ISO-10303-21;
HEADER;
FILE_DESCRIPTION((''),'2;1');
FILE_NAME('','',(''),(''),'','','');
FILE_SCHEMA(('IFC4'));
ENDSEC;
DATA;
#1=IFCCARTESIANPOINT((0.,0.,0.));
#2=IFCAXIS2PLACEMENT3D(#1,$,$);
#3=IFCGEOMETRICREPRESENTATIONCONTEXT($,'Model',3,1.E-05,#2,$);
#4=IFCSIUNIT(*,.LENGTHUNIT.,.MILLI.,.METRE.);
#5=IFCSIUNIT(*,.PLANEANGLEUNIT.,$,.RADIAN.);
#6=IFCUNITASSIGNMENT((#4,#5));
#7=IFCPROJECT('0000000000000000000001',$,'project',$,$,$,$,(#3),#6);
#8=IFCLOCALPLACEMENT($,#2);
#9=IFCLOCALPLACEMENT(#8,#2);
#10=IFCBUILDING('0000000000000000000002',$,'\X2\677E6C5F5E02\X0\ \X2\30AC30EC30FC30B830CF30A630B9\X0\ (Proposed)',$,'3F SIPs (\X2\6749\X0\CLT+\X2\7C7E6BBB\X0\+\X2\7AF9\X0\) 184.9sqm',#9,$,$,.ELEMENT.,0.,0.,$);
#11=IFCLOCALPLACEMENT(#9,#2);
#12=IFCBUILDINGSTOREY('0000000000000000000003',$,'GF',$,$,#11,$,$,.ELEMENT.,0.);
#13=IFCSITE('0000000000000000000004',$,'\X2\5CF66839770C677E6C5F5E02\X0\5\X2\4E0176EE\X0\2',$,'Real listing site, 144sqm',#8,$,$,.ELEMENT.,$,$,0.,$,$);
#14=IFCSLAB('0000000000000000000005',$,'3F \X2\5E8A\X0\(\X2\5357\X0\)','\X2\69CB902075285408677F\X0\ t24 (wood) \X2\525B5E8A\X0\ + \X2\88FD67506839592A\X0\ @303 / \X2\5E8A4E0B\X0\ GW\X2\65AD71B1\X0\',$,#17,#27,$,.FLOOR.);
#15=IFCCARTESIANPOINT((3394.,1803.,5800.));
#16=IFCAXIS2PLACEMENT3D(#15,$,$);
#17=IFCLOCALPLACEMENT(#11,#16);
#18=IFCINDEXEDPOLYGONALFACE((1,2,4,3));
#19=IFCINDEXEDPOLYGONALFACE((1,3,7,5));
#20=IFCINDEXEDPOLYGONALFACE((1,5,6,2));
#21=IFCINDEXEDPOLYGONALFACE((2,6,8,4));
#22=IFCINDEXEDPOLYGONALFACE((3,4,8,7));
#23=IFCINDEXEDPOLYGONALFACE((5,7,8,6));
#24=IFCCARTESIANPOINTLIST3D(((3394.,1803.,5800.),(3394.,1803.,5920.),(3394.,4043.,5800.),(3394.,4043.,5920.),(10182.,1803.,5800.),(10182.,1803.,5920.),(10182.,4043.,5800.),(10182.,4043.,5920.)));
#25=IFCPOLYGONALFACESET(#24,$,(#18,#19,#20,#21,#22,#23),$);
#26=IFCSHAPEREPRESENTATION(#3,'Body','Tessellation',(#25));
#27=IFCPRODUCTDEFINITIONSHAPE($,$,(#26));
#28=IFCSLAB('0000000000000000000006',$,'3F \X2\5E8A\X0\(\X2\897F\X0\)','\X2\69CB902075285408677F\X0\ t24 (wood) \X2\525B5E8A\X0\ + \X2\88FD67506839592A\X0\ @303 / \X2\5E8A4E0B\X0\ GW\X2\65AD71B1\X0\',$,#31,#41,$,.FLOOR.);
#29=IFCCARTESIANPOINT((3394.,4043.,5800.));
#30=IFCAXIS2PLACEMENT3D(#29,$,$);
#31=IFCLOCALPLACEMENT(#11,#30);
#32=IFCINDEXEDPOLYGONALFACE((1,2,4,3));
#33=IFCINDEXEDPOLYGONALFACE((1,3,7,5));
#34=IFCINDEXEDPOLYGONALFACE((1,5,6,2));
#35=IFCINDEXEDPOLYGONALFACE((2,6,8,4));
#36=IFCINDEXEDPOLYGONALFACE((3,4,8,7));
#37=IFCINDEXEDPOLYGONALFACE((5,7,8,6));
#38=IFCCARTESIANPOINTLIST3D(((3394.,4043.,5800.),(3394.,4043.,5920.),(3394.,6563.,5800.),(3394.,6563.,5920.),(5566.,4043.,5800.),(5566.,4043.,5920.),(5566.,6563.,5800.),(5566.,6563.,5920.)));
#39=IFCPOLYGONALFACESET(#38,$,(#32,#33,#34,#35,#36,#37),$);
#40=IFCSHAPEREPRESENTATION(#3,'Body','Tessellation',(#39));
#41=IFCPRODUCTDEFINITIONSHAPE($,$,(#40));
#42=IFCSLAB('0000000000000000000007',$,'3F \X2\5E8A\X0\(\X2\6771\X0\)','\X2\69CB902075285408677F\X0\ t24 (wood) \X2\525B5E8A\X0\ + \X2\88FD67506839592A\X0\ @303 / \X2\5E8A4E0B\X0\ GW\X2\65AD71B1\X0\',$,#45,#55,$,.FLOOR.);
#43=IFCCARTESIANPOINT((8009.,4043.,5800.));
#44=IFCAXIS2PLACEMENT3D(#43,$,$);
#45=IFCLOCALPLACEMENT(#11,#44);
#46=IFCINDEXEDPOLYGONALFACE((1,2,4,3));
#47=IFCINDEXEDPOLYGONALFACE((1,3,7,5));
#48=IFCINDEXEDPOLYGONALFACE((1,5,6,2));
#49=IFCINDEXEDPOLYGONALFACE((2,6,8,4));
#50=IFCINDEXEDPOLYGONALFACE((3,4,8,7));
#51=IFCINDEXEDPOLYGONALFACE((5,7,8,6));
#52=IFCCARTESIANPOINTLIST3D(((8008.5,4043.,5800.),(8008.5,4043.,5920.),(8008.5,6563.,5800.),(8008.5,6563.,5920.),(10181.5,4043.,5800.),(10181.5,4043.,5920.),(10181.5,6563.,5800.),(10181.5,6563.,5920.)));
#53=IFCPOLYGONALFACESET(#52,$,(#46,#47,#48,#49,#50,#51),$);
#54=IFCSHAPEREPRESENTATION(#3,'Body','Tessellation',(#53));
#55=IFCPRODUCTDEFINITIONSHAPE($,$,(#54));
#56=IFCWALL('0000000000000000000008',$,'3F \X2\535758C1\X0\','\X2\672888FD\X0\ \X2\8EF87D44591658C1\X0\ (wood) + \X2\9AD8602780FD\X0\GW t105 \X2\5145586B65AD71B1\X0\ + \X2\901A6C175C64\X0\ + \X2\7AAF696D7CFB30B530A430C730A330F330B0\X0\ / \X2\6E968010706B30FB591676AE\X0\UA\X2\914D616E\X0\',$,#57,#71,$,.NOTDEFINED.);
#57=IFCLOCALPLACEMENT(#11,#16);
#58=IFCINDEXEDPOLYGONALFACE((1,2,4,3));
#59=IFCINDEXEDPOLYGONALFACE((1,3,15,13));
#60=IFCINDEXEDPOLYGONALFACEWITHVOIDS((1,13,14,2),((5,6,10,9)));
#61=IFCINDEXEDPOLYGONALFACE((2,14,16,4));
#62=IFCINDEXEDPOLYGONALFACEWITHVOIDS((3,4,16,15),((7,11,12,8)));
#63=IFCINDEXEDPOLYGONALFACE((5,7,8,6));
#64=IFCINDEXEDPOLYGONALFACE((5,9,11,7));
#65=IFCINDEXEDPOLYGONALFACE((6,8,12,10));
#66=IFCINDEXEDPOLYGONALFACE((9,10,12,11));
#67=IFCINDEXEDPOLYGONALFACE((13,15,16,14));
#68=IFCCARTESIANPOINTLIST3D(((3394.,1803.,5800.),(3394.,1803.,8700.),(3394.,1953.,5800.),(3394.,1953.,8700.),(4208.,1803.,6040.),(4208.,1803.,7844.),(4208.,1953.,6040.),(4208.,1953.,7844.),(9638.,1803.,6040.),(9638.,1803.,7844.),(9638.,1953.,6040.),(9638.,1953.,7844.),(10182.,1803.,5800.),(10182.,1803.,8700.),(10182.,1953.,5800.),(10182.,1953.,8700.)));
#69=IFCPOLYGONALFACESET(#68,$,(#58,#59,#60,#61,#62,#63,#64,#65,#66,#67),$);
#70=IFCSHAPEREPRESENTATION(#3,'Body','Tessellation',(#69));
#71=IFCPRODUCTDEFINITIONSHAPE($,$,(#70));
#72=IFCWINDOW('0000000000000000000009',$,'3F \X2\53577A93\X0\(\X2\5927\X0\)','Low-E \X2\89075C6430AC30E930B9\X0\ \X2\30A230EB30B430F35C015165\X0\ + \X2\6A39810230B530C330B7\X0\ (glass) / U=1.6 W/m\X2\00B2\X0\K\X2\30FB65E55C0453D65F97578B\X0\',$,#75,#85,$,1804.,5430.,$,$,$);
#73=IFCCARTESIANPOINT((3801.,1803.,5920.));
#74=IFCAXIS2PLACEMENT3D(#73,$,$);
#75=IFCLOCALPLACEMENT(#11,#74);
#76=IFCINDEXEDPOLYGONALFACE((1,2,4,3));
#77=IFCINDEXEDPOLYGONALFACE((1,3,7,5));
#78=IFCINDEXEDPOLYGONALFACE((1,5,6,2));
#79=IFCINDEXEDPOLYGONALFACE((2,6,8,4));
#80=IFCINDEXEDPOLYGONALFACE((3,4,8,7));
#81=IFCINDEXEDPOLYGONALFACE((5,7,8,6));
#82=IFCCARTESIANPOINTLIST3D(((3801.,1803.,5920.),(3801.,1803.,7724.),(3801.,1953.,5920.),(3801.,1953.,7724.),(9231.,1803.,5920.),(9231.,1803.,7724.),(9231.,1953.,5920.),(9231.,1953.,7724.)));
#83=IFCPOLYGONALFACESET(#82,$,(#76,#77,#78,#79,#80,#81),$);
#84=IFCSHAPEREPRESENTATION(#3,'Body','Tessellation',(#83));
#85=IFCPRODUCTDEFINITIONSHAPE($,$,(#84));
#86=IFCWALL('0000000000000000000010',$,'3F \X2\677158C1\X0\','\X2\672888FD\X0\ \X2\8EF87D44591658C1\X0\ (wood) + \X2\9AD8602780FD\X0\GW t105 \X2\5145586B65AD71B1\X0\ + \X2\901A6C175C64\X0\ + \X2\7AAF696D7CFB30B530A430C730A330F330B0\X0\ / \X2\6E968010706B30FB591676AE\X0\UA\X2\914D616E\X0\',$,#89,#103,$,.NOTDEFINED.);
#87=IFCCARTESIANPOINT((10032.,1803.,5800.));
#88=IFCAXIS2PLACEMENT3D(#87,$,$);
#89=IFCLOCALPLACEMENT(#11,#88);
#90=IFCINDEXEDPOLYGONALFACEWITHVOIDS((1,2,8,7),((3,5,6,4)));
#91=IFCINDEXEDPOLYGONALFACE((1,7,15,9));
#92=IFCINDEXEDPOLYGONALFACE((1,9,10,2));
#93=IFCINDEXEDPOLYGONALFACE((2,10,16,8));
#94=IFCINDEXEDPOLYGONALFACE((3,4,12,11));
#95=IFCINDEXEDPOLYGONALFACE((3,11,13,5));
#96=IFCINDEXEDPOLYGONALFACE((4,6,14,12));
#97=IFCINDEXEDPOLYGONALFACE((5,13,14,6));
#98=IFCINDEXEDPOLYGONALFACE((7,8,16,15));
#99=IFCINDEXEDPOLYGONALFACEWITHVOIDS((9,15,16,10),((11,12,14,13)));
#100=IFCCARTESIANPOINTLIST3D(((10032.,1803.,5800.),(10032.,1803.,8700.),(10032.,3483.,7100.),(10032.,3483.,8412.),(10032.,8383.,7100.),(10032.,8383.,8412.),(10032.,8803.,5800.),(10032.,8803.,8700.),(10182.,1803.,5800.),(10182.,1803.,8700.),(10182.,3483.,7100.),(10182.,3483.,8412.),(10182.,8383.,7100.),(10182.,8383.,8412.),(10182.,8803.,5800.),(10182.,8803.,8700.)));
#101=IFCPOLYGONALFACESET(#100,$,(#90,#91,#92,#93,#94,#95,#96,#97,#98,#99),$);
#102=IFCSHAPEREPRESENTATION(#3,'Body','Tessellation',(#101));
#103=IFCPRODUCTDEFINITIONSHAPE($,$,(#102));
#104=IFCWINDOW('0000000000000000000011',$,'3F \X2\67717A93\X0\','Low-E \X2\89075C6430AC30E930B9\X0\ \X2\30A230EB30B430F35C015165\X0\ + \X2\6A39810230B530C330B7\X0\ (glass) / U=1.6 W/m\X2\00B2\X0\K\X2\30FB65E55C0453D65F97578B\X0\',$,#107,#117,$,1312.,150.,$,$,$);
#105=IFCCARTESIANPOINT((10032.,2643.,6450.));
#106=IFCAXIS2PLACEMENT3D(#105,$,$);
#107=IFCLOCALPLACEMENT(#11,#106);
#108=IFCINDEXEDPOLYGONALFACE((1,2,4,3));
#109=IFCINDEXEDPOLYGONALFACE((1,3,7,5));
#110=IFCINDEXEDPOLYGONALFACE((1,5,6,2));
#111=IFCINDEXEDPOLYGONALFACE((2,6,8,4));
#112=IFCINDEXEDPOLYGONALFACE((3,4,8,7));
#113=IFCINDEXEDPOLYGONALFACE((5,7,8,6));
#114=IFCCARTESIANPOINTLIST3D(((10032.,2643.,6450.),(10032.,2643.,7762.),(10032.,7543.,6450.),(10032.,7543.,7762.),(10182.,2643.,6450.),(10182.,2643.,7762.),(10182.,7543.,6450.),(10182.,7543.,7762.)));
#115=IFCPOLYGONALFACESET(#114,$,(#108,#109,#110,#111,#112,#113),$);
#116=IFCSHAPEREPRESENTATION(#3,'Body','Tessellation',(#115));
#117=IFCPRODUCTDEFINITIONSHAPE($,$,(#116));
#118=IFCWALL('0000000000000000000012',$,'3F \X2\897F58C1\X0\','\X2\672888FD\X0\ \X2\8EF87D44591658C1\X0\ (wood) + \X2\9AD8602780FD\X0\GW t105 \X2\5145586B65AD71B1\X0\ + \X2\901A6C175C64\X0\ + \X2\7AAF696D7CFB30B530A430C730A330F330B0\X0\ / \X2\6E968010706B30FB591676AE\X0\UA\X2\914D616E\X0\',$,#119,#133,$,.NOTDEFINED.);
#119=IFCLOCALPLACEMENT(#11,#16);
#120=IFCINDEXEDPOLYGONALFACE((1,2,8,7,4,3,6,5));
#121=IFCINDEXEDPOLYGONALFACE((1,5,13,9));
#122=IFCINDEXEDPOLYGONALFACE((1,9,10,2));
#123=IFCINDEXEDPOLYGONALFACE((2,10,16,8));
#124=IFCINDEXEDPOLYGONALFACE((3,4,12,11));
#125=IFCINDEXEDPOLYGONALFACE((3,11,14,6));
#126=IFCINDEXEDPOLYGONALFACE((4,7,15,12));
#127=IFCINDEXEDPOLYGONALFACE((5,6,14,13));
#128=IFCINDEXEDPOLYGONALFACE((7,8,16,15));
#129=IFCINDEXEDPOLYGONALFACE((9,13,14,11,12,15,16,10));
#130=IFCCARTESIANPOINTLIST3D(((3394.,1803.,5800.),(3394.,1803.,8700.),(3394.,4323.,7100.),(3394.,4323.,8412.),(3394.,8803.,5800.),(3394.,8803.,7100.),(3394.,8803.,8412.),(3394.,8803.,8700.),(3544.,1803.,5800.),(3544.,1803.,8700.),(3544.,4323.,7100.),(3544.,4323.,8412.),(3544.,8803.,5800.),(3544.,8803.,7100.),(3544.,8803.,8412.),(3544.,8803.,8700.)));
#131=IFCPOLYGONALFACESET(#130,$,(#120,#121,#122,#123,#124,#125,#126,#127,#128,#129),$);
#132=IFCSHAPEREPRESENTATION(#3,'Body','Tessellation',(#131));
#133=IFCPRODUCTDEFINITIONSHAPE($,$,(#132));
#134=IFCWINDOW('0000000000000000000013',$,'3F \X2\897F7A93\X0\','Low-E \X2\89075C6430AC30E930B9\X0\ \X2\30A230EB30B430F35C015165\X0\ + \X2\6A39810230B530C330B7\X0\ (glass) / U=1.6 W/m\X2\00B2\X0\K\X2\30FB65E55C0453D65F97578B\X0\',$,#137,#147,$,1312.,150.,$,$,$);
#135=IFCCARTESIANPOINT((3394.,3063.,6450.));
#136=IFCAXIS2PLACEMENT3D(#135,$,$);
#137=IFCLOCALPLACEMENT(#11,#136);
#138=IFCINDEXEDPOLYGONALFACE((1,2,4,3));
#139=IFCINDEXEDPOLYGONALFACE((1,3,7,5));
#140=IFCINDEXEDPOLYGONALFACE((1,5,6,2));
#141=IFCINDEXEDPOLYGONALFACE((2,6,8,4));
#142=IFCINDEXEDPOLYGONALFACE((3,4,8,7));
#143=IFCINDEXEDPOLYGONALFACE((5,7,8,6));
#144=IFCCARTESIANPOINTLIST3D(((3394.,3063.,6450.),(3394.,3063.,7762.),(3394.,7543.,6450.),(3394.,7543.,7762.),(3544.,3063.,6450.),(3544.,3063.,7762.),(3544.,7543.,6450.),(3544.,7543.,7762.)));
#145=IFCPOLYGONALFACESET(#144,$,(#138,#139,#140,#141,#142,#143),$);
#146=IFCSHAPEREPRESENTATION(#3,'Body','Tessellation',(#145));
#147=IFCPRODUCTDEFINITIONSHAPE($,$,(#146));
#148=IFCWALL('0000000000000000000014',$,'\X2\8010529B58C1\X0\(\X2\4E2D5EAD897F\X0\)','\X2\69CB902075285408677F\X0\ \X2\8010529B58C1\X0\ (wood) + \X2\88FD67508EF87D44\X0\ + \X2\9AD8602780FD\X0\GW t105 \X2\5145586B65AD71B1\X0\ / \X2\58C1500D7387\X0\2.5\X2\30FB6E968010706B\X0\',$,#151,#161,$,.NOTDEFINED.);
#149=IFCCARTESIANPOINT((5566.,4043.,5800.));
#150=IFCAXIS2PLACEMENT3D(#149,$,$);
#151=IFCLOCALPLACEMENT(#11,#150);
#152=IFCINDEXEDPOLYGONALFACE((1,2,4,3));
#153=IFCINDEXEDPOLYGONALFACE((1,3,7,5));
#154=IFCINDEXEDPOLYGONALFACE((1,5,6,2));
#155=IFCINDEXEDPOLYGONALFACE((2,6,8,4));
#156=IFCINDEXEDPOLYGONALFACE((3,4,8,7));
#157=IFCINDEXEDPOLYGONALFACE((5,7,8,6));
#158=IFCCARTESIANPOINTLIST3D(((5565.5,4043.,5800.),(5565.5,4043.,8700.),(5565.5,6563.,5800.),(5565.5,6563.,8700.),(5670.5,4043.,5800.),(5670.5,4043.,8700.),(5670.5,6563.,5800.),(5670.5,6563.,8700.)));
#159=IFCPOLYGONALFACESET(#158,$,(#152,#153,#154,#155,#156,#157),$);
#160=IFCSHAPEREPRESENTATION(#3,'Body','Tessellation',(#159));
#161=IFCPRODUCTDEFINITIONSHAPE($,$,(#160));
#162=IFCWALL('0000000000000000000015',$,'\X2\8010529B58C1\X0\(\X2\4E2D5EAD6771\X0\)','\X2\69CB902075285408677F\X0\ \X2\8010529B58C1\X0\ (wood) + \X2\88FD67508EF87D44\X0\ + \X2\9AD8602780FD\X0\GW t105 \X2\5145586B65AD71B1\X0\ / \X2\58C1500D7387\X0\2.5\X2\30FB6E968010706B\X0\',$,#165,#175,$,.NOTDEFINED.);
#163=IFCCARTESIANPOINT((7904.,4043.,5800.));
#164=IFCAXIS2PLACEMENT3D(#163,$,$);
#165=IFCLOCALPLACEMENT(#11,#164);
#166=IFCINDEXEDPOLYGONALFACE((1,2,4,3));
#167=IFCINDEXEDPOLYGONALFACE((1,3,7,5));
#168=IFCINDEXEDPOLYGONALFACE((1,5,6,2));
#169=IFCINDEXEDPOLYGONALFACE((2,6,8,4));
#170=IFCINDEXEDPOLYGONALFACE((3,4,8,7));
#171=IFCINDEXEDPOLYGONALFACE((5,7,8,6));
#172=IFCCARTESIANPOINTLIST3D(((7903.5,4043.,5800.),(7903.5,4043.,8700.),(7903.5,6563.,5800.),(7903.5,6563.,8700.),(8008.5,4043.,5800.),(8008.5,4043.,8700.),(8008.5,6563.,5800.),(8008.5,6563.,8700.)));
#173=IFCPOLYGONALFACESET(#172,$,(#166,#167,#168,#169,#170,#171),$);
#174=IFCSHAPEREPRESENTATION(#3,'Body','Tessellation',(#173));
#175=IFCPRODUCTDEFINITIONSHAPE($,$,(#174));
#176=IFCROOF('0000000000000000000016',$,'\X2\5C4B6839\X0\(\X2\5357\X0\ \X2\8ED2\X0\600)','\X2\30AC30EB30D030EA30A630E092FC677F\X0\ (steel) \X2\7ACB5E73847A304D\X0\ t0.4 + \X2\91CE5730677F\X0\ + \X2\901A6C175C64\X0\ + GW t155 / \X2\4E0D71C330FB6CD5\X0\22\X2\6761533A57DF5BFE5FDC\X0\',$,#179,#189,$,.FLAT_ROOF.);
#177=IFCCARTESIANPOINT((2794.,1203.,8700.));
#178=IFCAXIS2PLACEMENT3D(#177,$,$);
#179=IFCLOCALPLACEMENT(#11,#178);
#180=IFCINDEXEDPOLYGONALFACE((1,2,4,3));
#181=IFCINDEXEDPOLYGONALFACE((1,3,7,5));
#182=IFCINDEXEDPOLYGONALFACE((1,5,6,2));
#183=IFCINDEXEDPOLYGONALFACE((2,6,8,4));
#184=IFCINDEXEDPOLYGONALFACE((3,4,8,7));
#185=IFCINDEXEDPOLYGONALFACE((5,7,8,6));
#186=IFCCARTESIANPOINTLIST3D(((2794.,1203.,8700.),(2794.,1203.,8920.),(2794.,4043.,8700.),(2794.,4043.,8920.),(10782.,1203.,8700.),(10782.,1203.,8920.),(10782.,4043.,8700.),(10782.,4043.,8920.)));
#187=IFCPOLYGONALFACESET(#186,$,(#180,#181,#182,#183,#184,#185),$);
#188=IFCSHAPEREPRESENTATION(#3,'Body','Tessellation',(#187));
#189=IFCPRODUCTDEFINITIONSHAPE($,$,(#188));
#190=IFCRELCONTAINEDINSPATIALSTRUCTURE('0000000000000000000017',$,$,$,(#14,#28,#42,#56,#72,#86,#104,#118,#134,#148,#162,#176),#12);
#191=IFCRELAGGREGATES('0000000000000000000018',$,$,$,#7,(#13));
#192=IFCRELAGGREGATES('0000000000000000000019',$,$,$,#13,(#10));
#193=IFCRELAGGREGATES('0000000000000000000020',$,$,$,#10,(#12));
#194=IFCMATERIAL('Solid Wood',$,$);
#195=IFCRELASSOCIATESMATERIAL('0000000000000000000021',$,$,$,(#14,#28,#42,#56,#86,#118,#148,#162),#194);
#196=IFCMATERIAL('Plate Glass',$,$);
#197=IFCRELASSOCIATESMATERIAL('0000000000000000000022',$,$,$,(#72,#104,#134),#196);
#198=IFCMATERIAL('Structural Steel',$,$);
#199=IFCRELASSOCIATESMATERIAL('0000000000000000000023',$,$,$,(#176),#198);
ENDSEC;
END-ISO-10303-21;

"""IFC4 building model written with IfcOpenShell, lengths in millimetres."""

from ifc_helpers import new_model, si_unit, frame, frame_2d, origin, place, context, project, spatial, rectangle, extrude, material, element, fill, save


model = new_model("IFC4")

# Units and contexts
model_context = context("Model", 3, precision=1e-05, world=origin())
ifc_project = project(units=[si_unit("LENGTHUNIT", "METRE", prefix="MILLI"), si_unit("PLANEANGLEUNIT", "RADIAN")], contexts=[model_context])

# Site, building, storey
site_placement = place(None, origin())
site = spatial("IfcSite", under=ifc_project, at=site_placement, Name="島根県松江市5丁目2", ObjectType="Real listing site, 144sqm", CompositionType="ELEMENT", RefElevation=0.0)
building_placement = place(site_placement, origin())
building = spatial("IfcBuilding", under=site, at=building_placement, Name="松江市 ガレージハウス (Proposed)", ObjectType="3F SIPs (杉CLT+籾殻+竹) 184.9sqm", CompositionType="ELEMENT", ElevationOfRefHeight=0.0, ElevationOfTerrain=0.0)
storey_placement = place(building_placement, origin())
storey = spatial("IfcBuildingStorey", under=building, at=storey_placement, Name="GF", CompositionType="ELEMENT", Elevation=0.0)

# Slabs
ifc_material_1 = material(Name="Solid Wood")
slab_1_placement = place(storey_placement, frame((3394.0, 1803.0, 5800.0)))
element("IfcSlab", 1, at=slab_1_placement, inside=storey, material=ifc_material_1, Name="3F 床(南)", Description="構造用合板 t24 (wood) 剛床 + 製材根太 @303 / 床下 GW断熱", PredefinedType="FLOOR", context=model_context, shape_type="SweptSolid", body=[
    extrude(rectangle(XDim=6788.0, YDim=2240.0, at=frame_2d((3394.0, 1120.0))), frame((3394.0, 1803.0, 5800.0)), (0.0, 0.0, 1.0), 120.0),
])
slab_2_placement = place(storey_placement, frame((3394.0, 4043.0, 5800.0)))
element("IfcSlab", 2, at=slab_2_placement, inside=storey, material=ifc_material_1, Name="3F 床(西)", Description="構造用合板 t24 (wood) 剛床 + 製材根太 @303 / 床下 GW断熱", PredefinedType="FLOOR", context=model_context, shape_type="SweptSolid", body=[
    extrude(rectangle(XDim=2172.0, YDim=2520.0, at=frame_2d((1086.0, 1260.0))), frame((3394.0, 4043.0, 5800.0)), (0.0, 0.0, 1.0), 120.0),
])
slab_3_placement = place(storey_placement, frame((8009.0, 4043.0, 5800.0)))
element("IfcSlab", 3, at=slab_3_placement, inside=storey, material=ifc_material_1, Name="3F 床(東)", Description="構造用合板 t24 (wood) 剛床 + 製材根太 @303 / 床下 GW断熱", PredefinedType="FLOOR", context=model_context, shape_type="SweptSolid", body=[
    extrude(rectangle(XDim=2173.0, YDim=2520.0, at=frame_2d((1086.0, 1260.0))), frame((8009.0, 4043.0, 5800.0)), (0.0, 0.0, 1.0), 120.0),
])

# Walls, openings, windows
wall_1_placement = place(storey_placement, frame((3394.0, 1803.0, 5800.0)))
wall_1 = element("IfcWall", 4, at=wall_1_placement, inside=storey, material=ifc_material_1, Name="3F 南壁", Description="木製 軸組外壁 (wood) + 高性能GW t105 充填断熱 + 通気層 + 窯業系サイディング / 準耐火・外皮UA配慮", PredefinedType="NOTDEFINED", context=model_context, shape_type="SweptSolid", body=[
    extrude(rectangle(XDim=6788.0, YDim=150.0, at=frame_2d((3394.0, 75.0))), frame((3394.0, 1803.0, 5800.0)), (0.0, 0.0, 1.0), 2900.0),
])
opening_1_placement = place(storey_placement, frame((3801.0, 1803.0, 5920.0)))
opening_1 = element("IfcOpeningElement", 5, at=opening_1_placement, cuts=wall_1, PredefinedType="NOTDEFINED", context=model_context, shape_type="SweptSolid", body=[
    extrude(rectangle(XDim=5430.0, YDim=150.0, at=frame_2d((2715.0, 75.0))), frame((3801.0, 1803.0, 5920.0)), (0.0, 0.0, 1.0), 1804.0),
])
ifc_material_2 = material(Name="Plate Glass")
window_1_placement = place(storey_placement, frame((3801.0, 1803.0, 5920.0)))
window_1 = element("IfcWindow", 6, at=window_1_placement, inside=storey, material=ifc_material_2, Name="3F 南窓(大)", Description="Low-E 複層ガラス アルゴン封入 + 樹脂サッシ (glass) / U=1.6 W/m²K・日射取得型", OverallHeight=1804.0, OverallWidth=5430.0, context=model_context, shape_type="SweptSolid", body=[
    extrude(rectangle(XDim=5430.0, YDim=150.0, at=frame_2d((2715.0, 75.0))), frame((3801.0, 1803.0, 5920.0)), (0.0, 0.0, 1.0), 1804.0),
])
fill(opening_1, window_1)
wall_2_placement = place(storey_placement, frame((10032.0, 1803.0, 5800.0)))
wall_2 = element("IfcWall", 7, at=wall_2_placement, inside=storey, material=ifc_material_1, Name="3F 東壁", Description="木製 軸組外壁 (wood) + 高性能GW t105 充填断熱 + 通気層 + 窯業系サイディング / 準耐火・外皮UA配慮", PredefinedType="NOTDEFINED", context=model_context, shape_type="SweptSolid", body=[
    extrude(rectangle(XDim=150.0, YDim=7000.0, at=frame_2d((75.0, 3500.0))), frame((10032.0, 1803.0, 5800.0)), (0.0, 0.0, 1.0), 2900.0),
])
opening_2_placement = place(storey_placement, frame((10032.0, 2643.0, 6450.0)))
opening_2 = element("IfcOpeningElement", 8, at=opening_2_placement, cuts=wall_2, PredefinedType="NOTDEFINED", context=model_context, shape_type="SweptSolid", body=[
    extrude(rectangle(XDim=150.0, YDim=4900.0, at=frame_2d((75.0, 2450.0))), frame((10032.0, 2643.0, 6450.0)), (0.0, 0.0, 1.0), 1312.0),
])
window_2_placement = place(storey_placement, frame((10032.0, 2643.0, 6450.0)))
window_2 = element("IfcWindow", 9, at=window_2_placement, inside=storey, material=ifc_material_2, Name="3F 東窓", Description="Low-E 複層ガラス アルゴン封入 + 樹脂サッシ (glass) / U=1.6 W/m²K・日射取得型", OverallHeight=1312.0, OverallWidth=150.0, context=model_context, shape_type="SweptSolid", body=[
    extrude(rectangle(XDim=150.0, YDim=4900.0, at=frame_2d((75.0, 2450.0))), frame((10032.0, 2643.0, 6450.0)), (0.0, 0.0, 1.0), 1312.0),
])
fill(opening_2, window_2)
wall_3_placement = place(storey_placement, frame((3394.0, 1803.0, 5800.0)))
wall_3 = element("IfcWall", 10, at=wall_3_placement, inside=storey, material=ifc_material_1, Name="3F 西壁", Description="木製 軸組外壁 (wood) + 高性能GW t105 充填断熱 + 通気層 + 窯業系サイディング / 準耐火・外皮UA配慮", PredefinedType="NOTDEFINED", context=model_context, shape_type="SweptSolid", body=[
    extrude(rectangle(XDim=150.0, YDim=7000.0, at=frame_2d((75.0, 3500.0))), frame((3394.0, 1803.0, 5800.0)), (0.0, 0.0, 1.0), 2900.0),
])
opening_3_placement = place(storey_placement, frame((3394.0, 3063.0, 6450.0)))
opening_3 = element("IfcOpeningElement", 11, at=opening_3_placement, cuts=wall_3, PredefinedType="NOTDEFINED", context=model_context, shape_type="SweptSolid", body=[
    extrude(rectangle(XDim=150.0, YDim=4480.0, at=frame_2d((75.0, 2240.0))), frame((3394.0, 3063.0, 6450.0)), (0.0, 0.0, 1.0), 1312.0),
])
window_3_placement = place(storey_placement, frame((3394.0, 3063.0, 6450.0)))
window_3 = element("IfcWindow", 12, at=window_3_placement, inside=storey, material=ifc_material_2, Name="3F 西窓", Description="Low-E 複層ガラス アルゴン封入 + 樹脂サッシ (glass) / U=1.6 W/m²K・日射取得型", OverallHeight=1312.0, OverallWidth=150.0, context=model_context, shape_type="SweptSolid", body=[
    extrude(rectangle(XDim=150.0, YDim=4480.0, at=frame_2d((75.0, 2240.0))), frame((3394.0, 3063.0, 6450.0)), (0.0, 0.0, 1.0), 1312.0),
])
fill(opening_3, window_3)

# Walls
wall_4_placement = place(storey_placement, frame((5566.0, 4043.0, 5800.0)))
element("IfcWall", 13, at=wall_4_placement, inside=storey, material=ifc_material_1, Name="耐力壁(中庭西)", Description="構造用合板 耐力壁 (wood) + 製材軸組 + 高性能GW t105 充填断熱 / 壁倍率2.5・準耐火", PredefinedType="NOTDEFINED", context=model_context, shape_type="SweptSolid", body=[
    extrude(rectangle(XDim=105.0, YDim=2520.0, at=frame_2d((52.0, 1260.0))), frame((5566.0, 4043.0, 5800.0)), (0.0, 0.0, 1.0), 2900.0),
])
wall_5_placement = place(storey_placement, frame((7904.0, 4043.0, 5800.0)))
element("IfcWall", 14, at=wall_5_placement, inside=storey, material=ifc_material_1, Name="耐力壁(中庭東)", Description="構造用合板 耐力壁 (wood) + 製材軸組 + 高性能GW t105 充填断熱 / 壁倍率2.5・準耐火", PredefinedType="NOTDEFINED", context=model_context, shape_type="SweptSolid", body=[
    extrude(rectangle(XDim=105.0, YDim=2520.0, at=frame_2d((52.0, 1260.0))), frame((7904.0, 4043.0, 5800.0)), (0.0, 0.0, 1.0), 2900.0),
])

# Roof
ifc_material_3 = material(Name="Structural Steel")
roof_1_placement = place(storey_placement, frame((2794.0, 1203.0, 8700.0)))
element("IfcRoof", 15, at=roof_1_placement, inside=storey, material=ifc_material_3, Name="屋根(南 軒600)", Description="ガルバリウム鋼板 (steel) 立平葺き t0.4 + 野地板 + 通気層 + GW t155 / 不燃・法22条区域対応", PredefinedType="FLAT_ROOF", context=model_context, shape_type="SweptSolid", body=[
    extrude(rectangle(XDim=7988.0, YDim=2840.0, at=frame_2d((3994.0, 1420.0))), frame((2794.0, 1203.0, 8700.0)), (0.0, 0.0, 1.0), 220.0),
])

save(model, "model.ifc")
